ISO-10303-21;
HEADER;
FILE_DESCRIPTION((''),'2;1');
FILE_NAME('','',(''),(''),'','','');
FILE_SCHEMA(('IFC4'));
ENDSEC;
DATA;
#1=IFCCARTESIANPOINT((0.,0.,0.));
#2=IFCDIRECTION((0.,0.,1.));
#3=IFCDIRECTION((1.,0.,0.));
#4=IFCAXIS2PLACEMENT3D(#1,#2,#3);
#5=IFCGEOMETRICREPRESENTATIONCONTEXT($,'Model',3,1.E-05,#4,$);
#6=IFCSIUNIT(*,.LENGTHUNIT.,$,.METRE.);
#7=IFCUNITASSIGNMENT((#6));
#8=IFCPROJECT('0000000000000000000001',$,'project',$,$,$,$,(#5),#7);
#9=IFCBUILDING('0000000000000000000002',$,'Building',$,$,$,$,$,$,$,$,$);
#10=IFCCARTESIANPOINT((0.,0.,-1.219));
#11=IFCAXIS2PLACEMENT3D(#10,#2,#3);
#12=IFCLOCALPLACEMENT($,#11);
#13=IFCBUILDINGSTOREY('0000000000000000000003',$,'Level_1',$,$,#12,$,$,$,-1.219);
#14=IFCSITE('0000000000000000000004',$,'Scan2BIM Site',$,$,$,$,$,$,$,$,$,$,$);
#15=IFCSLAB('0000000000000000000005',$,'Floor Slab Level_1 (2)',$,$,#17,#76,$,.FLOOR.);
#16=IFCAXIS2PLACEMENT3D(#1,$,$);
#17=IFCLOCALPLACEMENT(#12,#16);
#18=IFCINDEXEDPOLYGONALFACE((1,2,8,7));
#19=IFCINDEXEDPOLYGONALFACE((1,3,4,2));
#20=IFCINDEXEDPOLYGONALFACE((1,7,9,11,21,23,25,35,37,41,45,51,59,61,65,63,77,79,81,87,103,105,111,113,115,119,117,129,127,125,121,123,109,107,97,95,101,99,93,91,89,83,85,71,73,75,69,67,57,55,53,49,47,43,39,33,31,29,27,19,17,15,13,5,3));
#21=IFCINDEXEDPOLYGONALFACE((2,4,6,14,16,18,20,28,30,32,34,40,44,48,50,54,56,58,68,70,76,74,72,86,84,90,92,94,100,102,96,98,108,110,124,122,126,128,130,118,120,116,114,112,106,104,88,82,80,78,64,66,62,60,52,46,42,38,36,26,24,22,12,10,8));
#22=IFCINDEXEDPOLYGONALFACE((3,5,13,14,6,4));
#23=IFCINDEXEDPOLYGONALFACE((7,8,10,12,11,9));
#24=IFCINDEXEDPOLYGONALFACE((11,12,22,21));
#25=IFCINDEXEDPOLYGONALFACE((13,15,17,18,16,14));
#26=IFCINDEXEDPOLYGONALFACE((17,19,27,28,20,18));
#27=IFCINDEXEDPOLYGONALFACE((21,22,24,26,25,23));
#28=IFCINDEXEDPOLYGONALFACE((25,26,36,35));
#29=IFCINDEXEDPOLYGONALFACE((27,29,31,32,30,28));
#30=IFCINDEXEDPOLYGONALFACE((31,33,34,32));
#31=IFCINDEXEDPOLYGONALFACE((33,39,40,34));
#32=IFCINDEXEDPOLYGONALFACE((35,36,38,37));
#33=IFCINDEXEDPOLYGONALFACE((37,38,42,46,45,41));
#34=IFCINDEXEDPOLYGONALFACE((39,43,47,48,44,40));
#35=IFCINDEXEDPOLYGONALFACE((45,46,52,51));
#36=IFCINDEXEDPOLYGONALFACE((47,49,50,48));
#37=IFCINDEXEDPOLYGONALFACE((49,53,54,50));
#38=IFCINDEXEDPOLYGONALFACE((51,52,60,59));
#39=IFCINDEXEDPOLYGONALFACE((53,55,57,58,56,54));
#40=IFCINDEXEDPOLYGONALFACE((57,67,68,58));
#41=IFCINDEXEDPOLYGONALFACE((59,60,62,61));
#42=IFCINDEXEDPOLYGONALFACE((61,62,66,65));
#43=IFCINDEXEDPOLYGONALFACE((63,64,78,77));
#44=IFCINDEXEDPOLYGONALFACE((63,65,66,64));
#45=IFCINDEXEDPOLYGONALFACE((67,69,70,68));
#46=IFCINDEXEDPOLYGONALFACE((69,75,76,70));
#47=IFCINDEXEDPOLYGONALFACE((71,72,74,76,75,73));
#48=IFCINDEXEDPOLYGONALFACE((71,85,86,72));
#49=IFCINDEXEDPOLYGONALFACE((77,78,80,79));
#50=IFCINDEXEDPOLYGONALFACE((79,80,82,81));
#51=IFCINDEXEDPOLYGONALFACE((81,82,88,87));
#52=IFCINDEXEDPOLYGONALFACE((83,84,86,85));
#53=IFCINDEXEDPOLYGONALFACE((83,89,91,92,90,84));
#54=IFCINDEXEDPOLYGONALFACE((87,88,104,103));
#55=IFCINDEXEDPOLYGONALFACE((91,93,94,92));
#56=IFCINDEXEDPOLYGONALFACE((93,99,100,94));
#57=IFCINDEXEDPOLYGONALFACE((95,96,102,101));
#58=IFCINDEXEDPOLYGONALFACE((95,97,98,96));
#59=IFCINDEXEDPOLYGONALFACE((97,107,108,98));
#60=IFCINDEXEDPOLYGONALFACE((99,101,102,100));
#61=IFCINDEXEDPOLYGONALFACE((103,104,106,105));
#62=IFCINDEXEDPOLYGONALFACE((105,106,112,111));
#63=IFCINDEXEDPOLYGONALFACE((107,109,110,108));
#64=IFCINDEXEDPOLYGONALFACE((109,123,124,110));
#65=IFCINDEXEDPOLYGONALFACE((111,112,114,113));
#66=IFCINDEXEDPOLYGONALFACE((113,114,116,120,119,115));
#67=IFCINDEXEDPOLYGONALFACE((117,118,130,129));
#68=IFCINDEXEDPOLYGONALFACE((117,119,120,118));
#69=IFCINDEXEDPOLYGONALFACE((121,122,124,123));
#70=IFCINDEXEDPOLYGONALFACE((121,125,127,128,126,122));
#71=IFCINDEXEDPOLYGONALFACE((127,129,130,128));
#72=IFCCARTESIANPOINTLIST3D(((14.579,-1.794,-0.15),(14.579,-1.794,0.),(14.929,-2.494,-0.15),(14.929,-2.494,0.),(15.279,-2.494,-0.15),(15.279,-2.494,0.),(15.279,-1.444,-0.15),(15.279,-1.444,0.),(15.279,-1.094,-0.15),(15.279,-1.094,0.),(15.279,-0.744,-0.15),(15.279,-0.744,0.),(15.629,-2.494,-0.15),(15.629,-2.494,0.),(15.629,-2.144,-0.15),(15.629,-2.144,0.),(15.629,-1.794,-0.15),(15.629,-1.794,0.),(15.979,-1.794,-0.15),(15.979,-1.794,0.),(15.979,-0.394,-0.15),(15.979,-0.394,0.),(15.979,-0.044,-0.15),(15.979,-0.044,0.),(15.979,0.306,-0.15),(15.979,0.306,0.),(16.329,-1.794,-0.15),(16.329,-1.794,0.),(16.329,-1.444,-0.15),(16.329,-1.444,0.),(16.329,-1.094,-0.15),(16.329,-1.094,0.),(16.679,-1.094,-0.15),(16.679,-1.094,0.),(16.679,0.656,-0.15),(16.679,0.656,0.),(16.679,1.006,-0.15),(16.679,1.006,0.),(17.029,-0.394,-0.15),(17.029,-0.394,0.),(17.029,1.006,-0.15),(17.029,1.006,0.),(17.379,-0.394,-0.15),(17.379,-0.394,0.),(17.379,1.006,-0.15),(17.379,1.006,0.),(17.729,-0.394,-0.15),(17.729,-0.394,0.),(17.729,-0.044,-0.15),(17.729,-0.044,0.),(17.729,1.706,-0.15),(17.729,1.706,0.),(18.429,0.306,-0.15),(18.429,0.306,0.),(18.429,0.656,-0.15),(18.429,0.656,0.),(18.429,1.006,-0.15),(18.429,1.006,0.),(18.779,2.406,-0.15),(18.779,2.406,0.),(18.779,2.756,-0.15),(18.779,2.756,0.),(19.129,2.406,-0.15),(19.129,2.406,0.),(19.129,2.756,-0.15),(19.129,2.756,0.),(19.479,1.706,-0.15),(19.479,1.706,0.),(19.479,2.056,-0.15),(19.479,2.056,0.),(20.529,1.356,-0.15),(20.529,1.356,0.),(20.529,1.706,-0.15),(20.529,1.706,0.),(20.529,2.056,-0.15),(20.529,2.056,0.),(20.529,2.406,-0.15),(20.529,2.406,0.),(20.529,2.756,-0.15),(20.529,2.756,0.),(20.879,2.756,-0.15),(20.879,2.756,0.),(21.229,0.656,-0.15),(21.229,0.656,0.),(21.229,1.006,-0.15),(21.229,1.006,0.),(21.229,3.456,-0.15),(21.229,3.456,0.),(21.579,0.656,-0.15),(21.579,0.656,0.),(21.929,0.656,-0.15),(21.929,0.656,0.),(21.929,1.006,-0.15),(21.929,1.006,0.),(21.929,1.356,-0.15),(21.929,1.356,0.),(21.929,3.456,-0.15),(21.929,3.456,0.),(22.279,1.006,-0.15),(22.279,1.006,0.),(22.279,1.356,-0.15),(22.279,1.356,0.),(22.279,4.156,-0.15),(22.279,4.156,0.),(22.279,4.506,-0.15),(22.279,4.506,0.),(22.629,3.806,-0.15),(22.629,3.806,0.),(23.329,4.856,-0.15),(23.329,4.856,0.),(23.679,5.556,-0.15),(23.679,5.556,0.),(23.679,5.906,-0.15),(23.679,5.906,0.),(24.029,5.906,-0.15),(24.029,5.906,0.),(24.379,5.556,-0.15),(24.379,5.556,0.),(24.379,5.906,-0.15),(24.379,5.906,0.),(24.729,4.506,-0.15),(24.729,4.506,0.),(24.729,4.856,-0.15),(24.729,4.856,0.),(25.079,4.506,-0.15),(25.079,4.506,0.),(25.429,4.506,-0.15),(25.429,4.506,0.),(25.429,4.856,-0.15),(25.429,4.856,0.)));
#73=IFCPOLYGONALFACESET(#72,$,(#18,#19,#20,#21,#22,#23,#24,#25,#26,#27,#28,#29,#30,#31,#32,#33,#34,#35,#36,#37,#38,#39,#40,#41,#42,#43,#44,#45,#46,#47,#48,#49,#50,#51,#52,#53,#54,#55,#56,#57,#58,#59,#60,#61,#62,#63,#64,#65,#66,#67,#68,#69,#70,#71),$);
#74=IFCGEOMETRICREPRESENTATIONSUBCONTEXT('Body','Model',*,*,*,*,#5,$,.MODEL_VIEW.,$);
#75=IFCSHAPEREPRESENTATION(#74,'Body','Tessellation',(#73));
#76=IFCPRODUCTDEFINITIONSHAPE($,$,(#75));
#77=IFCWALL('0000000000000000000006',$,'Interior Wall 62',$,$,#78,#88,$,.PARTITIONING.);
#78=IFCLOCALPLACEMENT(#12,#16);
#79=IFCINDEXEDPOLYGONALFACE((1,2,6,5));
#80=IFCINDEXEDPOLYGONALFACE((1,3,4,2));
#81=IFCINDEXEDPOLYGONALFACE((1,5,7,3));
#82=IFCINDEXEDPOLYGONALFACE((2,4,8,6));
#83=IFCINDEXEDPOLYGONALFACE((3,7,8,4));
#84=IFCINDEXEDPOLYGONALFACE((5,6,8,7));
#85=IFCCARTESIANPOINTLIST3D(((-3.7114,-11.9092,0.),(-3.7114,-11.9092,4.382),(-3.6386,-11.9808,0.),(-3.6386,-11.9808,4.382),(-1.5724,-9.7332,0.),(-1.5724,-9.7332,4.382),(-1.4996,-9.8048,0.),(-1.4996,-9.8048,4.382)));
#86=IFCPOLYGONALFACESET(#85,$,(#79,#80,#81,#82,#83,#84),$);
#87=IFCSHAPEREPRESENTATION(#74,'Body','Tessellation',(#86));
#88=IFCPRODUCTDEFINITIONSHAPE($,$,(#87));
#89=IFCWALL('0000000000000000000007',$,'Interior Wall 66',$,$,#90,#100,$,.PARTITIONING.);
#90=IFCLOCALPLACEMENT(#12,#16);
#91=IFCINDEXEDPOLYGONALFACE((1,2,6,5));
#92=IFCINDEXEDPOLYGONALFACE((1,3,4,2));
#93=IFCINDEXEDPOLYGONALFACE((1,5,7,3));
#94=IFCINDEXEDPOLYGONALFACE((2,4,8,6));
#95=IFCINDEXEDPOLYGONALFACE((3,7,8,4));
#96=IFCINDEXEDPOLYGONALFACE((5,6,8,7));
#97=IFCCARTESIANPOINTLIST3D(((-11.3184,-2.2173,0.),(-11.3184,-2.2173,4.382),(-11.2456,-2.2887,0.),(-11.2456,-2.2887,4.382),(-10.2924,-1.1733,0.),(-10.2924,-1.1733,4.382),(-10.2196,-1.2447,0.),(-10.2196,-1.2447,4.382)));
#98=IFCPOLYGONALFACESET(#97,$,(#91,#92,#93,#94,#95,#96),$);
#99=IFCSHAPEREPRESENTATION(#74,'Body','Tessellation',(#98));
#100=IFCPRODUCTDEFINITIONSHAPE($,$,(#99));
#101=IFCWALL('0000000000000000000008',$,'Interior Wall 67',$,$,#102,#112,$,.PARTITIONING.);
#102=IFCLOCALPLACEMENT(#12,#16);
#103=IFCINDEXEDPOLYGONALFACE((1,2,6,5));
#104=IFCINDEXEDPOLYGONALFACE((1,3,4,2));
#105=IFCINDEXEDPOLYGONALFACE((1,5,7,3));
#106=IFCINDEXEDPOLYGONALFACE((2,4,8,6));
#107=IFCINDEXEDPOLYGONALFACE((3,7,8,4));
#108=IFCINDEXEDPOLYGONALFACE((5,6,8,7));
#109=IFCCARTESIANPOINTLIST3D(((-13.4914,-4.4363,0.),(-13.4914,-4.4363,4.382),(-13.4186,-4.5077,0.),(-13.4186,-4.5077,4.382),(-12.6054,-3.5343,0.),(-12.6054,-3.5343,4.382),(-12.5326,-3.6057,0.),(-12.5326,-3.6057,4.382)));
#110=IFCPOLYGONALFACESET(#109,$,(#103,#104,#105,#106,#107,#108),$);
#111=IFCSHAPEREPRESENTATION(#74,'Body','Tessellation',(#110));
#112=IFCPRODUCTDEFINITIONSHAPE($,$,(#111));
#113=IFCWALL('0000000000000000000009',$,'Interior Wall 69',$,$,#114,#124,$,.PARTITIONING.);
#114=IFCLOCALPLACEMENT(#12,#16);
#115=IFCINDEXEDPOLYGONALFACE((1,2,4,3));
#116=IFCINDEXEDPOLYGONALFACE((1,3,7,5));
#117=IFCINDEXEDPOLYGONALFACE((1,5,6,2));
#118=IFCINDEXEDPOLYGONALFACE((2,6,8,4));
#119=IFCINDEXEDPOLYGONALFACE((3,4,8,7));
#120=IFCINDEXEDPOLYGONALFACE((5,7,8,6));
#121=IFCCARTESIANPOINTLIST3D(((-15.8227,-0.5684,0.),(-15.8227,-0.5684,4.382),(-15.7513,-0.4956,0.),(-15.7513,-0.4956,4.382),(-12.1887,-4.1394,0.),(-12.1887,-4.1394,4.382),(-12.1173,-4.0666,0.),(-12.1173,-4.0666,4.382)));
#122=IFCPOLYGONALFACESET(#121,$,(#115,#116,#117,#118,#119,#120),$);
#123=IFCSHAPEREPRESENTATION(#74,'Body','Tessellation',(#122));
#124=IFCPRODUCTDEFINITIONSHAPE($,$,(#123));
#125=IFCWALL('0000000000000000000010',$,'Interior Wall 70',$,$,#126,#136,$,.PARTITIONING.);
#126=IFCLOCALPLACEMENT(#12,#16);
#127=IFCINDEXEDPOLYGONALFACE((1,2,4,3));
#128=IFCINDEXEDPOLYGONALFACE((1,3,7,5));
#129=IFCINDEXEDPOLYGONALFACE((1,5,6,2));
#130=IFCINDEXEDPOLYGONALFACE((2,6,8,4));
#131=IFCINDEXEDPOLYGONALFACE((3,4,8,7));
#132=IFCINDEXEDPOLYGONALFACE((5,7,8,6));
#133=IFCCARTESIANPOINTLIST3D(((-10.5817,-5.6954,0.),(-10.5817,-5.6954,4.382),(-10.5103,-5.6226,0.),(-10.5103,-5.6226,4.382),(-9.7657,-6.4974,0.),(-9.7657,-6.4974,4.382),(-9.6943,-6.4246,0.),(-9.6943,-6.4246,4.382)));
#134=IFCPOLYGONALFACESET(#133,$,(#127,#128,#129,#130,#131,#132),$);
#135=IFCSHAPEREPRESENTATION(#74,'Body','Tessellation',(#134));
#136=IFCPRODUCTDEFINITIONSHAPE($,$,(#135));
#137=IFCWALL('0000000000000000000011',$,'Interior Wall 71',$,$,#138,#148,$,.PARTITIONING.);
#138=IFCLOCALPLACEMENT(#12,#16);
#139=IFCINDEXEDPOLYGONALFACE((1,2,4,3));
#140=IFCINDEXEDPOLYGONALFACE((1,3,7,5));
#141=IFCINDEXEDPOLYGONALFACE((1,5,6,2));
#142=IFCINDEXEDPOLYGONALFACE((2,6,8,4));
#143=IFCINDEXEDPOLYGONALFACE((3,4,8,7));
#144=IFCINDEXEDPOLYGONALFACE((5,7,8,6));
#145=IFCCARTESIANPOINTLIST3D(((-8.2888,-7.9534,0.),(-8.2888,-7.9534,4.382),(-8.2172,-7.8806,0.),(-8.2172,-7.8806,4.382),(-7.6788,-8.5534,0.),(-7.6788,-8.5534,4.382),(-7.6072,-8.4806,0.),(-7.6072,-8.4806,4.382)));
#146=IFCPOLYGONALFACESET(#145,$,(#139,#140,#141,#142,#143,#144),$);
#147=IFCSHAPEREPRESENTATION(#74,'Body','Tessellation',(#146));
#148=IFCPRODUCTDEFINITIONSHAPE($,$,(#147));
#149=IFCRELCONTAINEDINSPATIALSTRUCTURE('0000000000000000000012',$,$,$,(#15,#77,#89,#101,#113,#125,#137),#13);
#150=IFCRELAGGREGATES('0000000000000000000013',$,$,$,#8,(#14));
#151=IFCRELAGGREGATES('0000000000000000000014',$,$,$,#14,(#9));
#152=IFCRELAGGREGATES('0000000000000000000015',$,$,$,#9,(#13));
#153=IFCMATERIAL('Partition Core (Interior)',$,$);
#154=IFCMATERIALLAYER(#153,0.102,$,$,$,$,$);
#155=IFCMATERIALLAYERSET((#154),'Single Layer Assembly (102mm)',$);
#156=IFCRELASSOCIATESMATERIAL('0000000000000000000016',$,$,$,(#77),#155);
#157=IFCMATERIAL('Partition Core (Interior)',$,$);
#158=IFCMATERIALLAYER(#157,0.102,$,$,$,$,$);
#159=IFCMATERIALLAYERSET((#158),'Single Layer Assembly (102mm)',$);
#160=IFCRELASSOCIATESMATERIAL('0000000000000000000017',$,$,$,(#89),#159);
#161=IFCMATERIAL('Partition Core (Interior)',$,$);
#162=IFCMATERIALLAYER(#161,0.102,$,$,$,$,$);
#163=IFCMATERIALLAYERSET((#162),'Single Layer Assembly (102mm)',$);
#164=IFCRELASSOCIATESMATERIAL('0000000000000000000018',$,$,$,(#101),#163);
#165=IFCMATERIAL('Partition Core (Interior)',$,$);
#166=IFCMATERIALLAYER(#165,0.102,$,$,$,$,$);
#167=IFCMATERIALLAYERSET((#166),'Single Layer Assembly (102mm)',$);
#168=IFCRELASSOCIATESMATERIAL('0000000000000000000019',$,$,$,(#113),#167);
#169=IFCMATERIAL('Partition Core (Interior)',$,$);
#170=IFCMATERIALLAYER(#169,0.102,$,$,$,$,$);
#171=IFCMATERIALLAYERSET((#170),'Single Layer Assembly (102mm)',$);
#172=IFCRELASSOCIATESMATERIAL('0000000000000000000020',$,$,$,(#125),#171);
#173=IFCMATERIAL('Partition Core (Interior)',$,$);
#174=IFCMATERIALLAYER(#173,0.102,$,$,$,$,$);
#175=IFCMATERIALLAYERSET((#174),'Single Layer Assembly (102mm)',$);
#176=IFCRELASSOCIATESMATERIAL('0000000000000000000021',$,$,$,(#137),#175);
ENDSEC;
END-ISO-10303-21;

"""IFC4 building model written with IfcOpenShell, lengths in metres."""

from ifc_helpers import new_model, si_unit, frame, origin, origin_with_axes, place, context, subcontext, project, spatial, polyline, rectangle, outline, extrude, material, layer, layer_set, element, save


model = new_model("IFC4")

# Units and contexts
model_context = context("Model", 3, precision=1e-05, world=origin_with_axes())
body_context = subcontext(model_context, "Body", "Model", "MODEL_VIEW")
ifc_project = project(units=[si_unit("LENGTHUNIT", "METRE")], contexts=[model_context])

# Site, building, storey
site = spatial("IfcSite", under=ifc_project, Name="Scan2BIM Site")
building = spatial("IfcBuilding", under=site, Name="Building")
storey_placement = place(None, frame((0.0, 0.0, -1.219), z_axis=(0.0, 0.0, 1.0), x_axis=(1.0, 0.0, 0.0)))
storey = spatial("IfcBuildingStorey", under=building, at=storey_placement, Name="Level_1", Elevation=-1.219)

# Slab
slab_1_placement = place(storey_placement, frame((0.0, 0.0, -0.15), z_axis=(0.0, 0.0, 1.0), x_axis=(1.0, 0.0, 0.0)))
element("IfcSlab", 1, at=slab_1_placement, inside=storey, Name="Floor Slab Level_1 (2)", PredefinedType="FLOOR", context=body_context, shape_type="SweptSolid", body=[
    extrude(outline(polyline([(14.929, -2.494), (15.279, -2.494), (15.629, -2.494), (15.629, -2.144), (15.629, -1.794), (15.979, -1.794), (16.329, -1.794), (16.329, -1.444), (16.329, -1.094), (16.679, -1.094), (17.029, -0.394), (17.379, -0.394), (17.729, -0.394), (17.729, -0.044), (18.429, 0.306), (18.429, 0.656), (18.429, 1.006), (19.479, 1.706), (19.479, 2.056), (20.529, 2.056), (20.529, 1.706), (20.529, 1.356), (21.229, 1.006), (21.229, 0.656), (21.579, 0.656), (21.929, 0.656), (21.929, 1.006), (22.279, 1.006), (22.279, 1.356), (21.929, 1.356), (21.929, 3.456), (22.629, 3.806), (23.329, 4.856), (24.729, 4.856), (24.729, 4.506), (25.079, 4.506), (25.429, 4.506), (25.429, 4.856), (24.379, 5.556), (24.379, 5.906), (24.029, 5.906), (23.679, 5.906), (23.679, 5.556), (22.279, 4.506), (22.279, 4.156), (21.229, 3.456), (20.879, 2.756), (20.529, 2.756), (20.529, 2.406), (19.129, 2.406), (19.129, 2.756), (18.779, 2.756), (18.779, 2.406), (17.729, 1.706), (17.379, 1.006), (17.029, 1.006), (16.679, 1.006), (16.679, 0.656), (15.979, 0.306), (15.979, -0.044), (15.979, -0.394), (15.279, -0.744), (15.279, -1.094), (15.279, -1.444), (14.579, -1.794), (14.929, -2.494)])), origin(), (0.0, 0.0, 1.0), 0.15),
])

# Walls
ifc_material_1 = material(Name="Partition Core (Interior)")
ifc_layer_1 = layer(ifc_material_1, 0.102)
ifc_layer_set_1 = layer_set([ifc_layer_1], Name="Single Layer Assembly (102mm)")
wall_1_placement = place(storey_placement, frame((-2.6055, -10.857, 0.0), z_axis=(0.0, 0.0, 1.0), x_axis=(-0.701018, -0.713144, 0.0)))
element("IfcWall", 2, at=wall_1_placement, inside=storey, material=ifc_layer_set_1, Name="Interior Wall 62", PredefinedType="PARTITIONING", context=body_context, shape_type="SweptSolid", body=[
    extrude(rectangle(XDim=3.0513, YDim=0.102), origin(), (0.0, 0.0, 1.0), 4.382),
])
ifc_material_2 = material(Name="Partition Core (Interior)")
ifc_layer_2 = layer(ifc_material_2, 0.102)
ifc_layer_set_2 = layer_set([ifc_layer_2], Name="Single Layer Assembly (102mm)")
wall_2_placement = place(storey_placement, frame((-10.769, -1.731, 0.0), z_axis=(0.0, 0.0, 1.0), x_axis=(-0.700932, -0.713229, 0.0)))
element("IfcWall", 3, at=wall_2_placement, inside=storey, material=ifc_layer_set_2, Name="Interior Wall 66", PredefinedType="PARTITIONING", context=body_context, shape_type="SweptSolid", body=[
    extrude(rectangle(XDim=1.4638, YDim=0.102), origin(), (0.0, 0.0, 1.0), 4.382),
])
ifc_material_3 = material(Name="Partition Core (Interior)")
ifc_layer_3 = layer(ifc_material_3, 0.102)
ifc_layer_set_3 = layer_set([ifc_layer_3], Name="Single Layer Assembly (102mm)")
wall_3_placement = place(storey_placement, frame((-13.012, -4.021, 0.0), z_axis=(0.0, 0.0, 1.0), x_axis=(-0.700751, -0.713406, 0.0)))
element("IfcWall", 4, at=wall_3_placement, inside=storey, material=ifc_layer_set_3, Name="Interior Wall 67", PredefinedType="PARTITIONING", context=body_context, shape_type="SweptSolid", body=[
    extrude(rectangle(XDim=1.2644, YDim=0.102), origin(), (0.0, 0.0, 1.0), 4.382),
])
ifc_material_4 = material(Name="Partition Core (Interior)")
ifc_layer_4 = layer(ifc_material_4, 0.102)
ifc_layer_set_4 = layer_set([ifc_layer_4], Name="Single Layer Assembly (102mm)")
wall_4_placement = place(storey_placement, frame((-13.97, -2.3175, 0.0), z_axis=(0.0, 0.0, 1.0), x_axis=(0.713262, -0.700897, 0.0)))
element("IfcWall", 5, at=wall_4_placement, inside=storey, material=ifc_layer_set_4, Name="Interior Wall 69", PredefinedType="PARTITIONING", context=body_context, shape_type="SweptSolid", body=[
    extrude(rectangle(XDim=5.0949, YDim=0.102), origin(), (0.0, 0.0, 1.0), 4.382),
])
ifc_material_5 = material(Name="Partition Core (Interior)")
ifc_layer_5 = layer(ifc_material_5, 0.102)
ifc_layer_set_5 = layer_set([ifc_layer_5], Name="Single Layer Assembly (102mm)")
wall_5_placement = place(storey_placement, frame((-10.138, -6.06, 0.0), z_axis=(0.0, 0.0, 1.0), x_axis=(0.713198, -0.700962, 0.0)))
element("IfcWall", 6, at=wall_5_placement, inside=storey, material=ifc_layer_set_5, Name="Interior Wall 70", PredefinedType="PARTITIONING", context=body_context, shape_type="SweptSolid", body=[
    extrude(rectangle(XDim=1.1441, YDim=0.102), origin(), (0.0, 0.0, 1.0), 4.382),
])
ifc_material_6 = material(Name="Partition Core (Interior)")
ifc_layer_6 = layer(ifc_material_6, 0.102)
ifc_layer_set_6 = layer_set([ifc_layer_6], Name="Single Layer Assembly (102mm)")
wall_6_placement = place(storey_placement, frame((-7.948, -8.217, 0.0), z_axis=(0.0, 0.0, 1.0), x_axis=(0.712926, -0.701239, 0.0)))
element("IfcWall", 7, at=wall_6_placement, inside=storey, material=ifc_layer_set_6, Name="Interior Wall 71", PredefinedType="PARTITIONING", context=body_context, shape_type="SweptSolid", body=[
    extrude(rectangle(XDim=0.8556, YDim=0.102), origin(), (0.0, 0.0, 1.0), 4.382),
])

save(model, "model.ifc")
